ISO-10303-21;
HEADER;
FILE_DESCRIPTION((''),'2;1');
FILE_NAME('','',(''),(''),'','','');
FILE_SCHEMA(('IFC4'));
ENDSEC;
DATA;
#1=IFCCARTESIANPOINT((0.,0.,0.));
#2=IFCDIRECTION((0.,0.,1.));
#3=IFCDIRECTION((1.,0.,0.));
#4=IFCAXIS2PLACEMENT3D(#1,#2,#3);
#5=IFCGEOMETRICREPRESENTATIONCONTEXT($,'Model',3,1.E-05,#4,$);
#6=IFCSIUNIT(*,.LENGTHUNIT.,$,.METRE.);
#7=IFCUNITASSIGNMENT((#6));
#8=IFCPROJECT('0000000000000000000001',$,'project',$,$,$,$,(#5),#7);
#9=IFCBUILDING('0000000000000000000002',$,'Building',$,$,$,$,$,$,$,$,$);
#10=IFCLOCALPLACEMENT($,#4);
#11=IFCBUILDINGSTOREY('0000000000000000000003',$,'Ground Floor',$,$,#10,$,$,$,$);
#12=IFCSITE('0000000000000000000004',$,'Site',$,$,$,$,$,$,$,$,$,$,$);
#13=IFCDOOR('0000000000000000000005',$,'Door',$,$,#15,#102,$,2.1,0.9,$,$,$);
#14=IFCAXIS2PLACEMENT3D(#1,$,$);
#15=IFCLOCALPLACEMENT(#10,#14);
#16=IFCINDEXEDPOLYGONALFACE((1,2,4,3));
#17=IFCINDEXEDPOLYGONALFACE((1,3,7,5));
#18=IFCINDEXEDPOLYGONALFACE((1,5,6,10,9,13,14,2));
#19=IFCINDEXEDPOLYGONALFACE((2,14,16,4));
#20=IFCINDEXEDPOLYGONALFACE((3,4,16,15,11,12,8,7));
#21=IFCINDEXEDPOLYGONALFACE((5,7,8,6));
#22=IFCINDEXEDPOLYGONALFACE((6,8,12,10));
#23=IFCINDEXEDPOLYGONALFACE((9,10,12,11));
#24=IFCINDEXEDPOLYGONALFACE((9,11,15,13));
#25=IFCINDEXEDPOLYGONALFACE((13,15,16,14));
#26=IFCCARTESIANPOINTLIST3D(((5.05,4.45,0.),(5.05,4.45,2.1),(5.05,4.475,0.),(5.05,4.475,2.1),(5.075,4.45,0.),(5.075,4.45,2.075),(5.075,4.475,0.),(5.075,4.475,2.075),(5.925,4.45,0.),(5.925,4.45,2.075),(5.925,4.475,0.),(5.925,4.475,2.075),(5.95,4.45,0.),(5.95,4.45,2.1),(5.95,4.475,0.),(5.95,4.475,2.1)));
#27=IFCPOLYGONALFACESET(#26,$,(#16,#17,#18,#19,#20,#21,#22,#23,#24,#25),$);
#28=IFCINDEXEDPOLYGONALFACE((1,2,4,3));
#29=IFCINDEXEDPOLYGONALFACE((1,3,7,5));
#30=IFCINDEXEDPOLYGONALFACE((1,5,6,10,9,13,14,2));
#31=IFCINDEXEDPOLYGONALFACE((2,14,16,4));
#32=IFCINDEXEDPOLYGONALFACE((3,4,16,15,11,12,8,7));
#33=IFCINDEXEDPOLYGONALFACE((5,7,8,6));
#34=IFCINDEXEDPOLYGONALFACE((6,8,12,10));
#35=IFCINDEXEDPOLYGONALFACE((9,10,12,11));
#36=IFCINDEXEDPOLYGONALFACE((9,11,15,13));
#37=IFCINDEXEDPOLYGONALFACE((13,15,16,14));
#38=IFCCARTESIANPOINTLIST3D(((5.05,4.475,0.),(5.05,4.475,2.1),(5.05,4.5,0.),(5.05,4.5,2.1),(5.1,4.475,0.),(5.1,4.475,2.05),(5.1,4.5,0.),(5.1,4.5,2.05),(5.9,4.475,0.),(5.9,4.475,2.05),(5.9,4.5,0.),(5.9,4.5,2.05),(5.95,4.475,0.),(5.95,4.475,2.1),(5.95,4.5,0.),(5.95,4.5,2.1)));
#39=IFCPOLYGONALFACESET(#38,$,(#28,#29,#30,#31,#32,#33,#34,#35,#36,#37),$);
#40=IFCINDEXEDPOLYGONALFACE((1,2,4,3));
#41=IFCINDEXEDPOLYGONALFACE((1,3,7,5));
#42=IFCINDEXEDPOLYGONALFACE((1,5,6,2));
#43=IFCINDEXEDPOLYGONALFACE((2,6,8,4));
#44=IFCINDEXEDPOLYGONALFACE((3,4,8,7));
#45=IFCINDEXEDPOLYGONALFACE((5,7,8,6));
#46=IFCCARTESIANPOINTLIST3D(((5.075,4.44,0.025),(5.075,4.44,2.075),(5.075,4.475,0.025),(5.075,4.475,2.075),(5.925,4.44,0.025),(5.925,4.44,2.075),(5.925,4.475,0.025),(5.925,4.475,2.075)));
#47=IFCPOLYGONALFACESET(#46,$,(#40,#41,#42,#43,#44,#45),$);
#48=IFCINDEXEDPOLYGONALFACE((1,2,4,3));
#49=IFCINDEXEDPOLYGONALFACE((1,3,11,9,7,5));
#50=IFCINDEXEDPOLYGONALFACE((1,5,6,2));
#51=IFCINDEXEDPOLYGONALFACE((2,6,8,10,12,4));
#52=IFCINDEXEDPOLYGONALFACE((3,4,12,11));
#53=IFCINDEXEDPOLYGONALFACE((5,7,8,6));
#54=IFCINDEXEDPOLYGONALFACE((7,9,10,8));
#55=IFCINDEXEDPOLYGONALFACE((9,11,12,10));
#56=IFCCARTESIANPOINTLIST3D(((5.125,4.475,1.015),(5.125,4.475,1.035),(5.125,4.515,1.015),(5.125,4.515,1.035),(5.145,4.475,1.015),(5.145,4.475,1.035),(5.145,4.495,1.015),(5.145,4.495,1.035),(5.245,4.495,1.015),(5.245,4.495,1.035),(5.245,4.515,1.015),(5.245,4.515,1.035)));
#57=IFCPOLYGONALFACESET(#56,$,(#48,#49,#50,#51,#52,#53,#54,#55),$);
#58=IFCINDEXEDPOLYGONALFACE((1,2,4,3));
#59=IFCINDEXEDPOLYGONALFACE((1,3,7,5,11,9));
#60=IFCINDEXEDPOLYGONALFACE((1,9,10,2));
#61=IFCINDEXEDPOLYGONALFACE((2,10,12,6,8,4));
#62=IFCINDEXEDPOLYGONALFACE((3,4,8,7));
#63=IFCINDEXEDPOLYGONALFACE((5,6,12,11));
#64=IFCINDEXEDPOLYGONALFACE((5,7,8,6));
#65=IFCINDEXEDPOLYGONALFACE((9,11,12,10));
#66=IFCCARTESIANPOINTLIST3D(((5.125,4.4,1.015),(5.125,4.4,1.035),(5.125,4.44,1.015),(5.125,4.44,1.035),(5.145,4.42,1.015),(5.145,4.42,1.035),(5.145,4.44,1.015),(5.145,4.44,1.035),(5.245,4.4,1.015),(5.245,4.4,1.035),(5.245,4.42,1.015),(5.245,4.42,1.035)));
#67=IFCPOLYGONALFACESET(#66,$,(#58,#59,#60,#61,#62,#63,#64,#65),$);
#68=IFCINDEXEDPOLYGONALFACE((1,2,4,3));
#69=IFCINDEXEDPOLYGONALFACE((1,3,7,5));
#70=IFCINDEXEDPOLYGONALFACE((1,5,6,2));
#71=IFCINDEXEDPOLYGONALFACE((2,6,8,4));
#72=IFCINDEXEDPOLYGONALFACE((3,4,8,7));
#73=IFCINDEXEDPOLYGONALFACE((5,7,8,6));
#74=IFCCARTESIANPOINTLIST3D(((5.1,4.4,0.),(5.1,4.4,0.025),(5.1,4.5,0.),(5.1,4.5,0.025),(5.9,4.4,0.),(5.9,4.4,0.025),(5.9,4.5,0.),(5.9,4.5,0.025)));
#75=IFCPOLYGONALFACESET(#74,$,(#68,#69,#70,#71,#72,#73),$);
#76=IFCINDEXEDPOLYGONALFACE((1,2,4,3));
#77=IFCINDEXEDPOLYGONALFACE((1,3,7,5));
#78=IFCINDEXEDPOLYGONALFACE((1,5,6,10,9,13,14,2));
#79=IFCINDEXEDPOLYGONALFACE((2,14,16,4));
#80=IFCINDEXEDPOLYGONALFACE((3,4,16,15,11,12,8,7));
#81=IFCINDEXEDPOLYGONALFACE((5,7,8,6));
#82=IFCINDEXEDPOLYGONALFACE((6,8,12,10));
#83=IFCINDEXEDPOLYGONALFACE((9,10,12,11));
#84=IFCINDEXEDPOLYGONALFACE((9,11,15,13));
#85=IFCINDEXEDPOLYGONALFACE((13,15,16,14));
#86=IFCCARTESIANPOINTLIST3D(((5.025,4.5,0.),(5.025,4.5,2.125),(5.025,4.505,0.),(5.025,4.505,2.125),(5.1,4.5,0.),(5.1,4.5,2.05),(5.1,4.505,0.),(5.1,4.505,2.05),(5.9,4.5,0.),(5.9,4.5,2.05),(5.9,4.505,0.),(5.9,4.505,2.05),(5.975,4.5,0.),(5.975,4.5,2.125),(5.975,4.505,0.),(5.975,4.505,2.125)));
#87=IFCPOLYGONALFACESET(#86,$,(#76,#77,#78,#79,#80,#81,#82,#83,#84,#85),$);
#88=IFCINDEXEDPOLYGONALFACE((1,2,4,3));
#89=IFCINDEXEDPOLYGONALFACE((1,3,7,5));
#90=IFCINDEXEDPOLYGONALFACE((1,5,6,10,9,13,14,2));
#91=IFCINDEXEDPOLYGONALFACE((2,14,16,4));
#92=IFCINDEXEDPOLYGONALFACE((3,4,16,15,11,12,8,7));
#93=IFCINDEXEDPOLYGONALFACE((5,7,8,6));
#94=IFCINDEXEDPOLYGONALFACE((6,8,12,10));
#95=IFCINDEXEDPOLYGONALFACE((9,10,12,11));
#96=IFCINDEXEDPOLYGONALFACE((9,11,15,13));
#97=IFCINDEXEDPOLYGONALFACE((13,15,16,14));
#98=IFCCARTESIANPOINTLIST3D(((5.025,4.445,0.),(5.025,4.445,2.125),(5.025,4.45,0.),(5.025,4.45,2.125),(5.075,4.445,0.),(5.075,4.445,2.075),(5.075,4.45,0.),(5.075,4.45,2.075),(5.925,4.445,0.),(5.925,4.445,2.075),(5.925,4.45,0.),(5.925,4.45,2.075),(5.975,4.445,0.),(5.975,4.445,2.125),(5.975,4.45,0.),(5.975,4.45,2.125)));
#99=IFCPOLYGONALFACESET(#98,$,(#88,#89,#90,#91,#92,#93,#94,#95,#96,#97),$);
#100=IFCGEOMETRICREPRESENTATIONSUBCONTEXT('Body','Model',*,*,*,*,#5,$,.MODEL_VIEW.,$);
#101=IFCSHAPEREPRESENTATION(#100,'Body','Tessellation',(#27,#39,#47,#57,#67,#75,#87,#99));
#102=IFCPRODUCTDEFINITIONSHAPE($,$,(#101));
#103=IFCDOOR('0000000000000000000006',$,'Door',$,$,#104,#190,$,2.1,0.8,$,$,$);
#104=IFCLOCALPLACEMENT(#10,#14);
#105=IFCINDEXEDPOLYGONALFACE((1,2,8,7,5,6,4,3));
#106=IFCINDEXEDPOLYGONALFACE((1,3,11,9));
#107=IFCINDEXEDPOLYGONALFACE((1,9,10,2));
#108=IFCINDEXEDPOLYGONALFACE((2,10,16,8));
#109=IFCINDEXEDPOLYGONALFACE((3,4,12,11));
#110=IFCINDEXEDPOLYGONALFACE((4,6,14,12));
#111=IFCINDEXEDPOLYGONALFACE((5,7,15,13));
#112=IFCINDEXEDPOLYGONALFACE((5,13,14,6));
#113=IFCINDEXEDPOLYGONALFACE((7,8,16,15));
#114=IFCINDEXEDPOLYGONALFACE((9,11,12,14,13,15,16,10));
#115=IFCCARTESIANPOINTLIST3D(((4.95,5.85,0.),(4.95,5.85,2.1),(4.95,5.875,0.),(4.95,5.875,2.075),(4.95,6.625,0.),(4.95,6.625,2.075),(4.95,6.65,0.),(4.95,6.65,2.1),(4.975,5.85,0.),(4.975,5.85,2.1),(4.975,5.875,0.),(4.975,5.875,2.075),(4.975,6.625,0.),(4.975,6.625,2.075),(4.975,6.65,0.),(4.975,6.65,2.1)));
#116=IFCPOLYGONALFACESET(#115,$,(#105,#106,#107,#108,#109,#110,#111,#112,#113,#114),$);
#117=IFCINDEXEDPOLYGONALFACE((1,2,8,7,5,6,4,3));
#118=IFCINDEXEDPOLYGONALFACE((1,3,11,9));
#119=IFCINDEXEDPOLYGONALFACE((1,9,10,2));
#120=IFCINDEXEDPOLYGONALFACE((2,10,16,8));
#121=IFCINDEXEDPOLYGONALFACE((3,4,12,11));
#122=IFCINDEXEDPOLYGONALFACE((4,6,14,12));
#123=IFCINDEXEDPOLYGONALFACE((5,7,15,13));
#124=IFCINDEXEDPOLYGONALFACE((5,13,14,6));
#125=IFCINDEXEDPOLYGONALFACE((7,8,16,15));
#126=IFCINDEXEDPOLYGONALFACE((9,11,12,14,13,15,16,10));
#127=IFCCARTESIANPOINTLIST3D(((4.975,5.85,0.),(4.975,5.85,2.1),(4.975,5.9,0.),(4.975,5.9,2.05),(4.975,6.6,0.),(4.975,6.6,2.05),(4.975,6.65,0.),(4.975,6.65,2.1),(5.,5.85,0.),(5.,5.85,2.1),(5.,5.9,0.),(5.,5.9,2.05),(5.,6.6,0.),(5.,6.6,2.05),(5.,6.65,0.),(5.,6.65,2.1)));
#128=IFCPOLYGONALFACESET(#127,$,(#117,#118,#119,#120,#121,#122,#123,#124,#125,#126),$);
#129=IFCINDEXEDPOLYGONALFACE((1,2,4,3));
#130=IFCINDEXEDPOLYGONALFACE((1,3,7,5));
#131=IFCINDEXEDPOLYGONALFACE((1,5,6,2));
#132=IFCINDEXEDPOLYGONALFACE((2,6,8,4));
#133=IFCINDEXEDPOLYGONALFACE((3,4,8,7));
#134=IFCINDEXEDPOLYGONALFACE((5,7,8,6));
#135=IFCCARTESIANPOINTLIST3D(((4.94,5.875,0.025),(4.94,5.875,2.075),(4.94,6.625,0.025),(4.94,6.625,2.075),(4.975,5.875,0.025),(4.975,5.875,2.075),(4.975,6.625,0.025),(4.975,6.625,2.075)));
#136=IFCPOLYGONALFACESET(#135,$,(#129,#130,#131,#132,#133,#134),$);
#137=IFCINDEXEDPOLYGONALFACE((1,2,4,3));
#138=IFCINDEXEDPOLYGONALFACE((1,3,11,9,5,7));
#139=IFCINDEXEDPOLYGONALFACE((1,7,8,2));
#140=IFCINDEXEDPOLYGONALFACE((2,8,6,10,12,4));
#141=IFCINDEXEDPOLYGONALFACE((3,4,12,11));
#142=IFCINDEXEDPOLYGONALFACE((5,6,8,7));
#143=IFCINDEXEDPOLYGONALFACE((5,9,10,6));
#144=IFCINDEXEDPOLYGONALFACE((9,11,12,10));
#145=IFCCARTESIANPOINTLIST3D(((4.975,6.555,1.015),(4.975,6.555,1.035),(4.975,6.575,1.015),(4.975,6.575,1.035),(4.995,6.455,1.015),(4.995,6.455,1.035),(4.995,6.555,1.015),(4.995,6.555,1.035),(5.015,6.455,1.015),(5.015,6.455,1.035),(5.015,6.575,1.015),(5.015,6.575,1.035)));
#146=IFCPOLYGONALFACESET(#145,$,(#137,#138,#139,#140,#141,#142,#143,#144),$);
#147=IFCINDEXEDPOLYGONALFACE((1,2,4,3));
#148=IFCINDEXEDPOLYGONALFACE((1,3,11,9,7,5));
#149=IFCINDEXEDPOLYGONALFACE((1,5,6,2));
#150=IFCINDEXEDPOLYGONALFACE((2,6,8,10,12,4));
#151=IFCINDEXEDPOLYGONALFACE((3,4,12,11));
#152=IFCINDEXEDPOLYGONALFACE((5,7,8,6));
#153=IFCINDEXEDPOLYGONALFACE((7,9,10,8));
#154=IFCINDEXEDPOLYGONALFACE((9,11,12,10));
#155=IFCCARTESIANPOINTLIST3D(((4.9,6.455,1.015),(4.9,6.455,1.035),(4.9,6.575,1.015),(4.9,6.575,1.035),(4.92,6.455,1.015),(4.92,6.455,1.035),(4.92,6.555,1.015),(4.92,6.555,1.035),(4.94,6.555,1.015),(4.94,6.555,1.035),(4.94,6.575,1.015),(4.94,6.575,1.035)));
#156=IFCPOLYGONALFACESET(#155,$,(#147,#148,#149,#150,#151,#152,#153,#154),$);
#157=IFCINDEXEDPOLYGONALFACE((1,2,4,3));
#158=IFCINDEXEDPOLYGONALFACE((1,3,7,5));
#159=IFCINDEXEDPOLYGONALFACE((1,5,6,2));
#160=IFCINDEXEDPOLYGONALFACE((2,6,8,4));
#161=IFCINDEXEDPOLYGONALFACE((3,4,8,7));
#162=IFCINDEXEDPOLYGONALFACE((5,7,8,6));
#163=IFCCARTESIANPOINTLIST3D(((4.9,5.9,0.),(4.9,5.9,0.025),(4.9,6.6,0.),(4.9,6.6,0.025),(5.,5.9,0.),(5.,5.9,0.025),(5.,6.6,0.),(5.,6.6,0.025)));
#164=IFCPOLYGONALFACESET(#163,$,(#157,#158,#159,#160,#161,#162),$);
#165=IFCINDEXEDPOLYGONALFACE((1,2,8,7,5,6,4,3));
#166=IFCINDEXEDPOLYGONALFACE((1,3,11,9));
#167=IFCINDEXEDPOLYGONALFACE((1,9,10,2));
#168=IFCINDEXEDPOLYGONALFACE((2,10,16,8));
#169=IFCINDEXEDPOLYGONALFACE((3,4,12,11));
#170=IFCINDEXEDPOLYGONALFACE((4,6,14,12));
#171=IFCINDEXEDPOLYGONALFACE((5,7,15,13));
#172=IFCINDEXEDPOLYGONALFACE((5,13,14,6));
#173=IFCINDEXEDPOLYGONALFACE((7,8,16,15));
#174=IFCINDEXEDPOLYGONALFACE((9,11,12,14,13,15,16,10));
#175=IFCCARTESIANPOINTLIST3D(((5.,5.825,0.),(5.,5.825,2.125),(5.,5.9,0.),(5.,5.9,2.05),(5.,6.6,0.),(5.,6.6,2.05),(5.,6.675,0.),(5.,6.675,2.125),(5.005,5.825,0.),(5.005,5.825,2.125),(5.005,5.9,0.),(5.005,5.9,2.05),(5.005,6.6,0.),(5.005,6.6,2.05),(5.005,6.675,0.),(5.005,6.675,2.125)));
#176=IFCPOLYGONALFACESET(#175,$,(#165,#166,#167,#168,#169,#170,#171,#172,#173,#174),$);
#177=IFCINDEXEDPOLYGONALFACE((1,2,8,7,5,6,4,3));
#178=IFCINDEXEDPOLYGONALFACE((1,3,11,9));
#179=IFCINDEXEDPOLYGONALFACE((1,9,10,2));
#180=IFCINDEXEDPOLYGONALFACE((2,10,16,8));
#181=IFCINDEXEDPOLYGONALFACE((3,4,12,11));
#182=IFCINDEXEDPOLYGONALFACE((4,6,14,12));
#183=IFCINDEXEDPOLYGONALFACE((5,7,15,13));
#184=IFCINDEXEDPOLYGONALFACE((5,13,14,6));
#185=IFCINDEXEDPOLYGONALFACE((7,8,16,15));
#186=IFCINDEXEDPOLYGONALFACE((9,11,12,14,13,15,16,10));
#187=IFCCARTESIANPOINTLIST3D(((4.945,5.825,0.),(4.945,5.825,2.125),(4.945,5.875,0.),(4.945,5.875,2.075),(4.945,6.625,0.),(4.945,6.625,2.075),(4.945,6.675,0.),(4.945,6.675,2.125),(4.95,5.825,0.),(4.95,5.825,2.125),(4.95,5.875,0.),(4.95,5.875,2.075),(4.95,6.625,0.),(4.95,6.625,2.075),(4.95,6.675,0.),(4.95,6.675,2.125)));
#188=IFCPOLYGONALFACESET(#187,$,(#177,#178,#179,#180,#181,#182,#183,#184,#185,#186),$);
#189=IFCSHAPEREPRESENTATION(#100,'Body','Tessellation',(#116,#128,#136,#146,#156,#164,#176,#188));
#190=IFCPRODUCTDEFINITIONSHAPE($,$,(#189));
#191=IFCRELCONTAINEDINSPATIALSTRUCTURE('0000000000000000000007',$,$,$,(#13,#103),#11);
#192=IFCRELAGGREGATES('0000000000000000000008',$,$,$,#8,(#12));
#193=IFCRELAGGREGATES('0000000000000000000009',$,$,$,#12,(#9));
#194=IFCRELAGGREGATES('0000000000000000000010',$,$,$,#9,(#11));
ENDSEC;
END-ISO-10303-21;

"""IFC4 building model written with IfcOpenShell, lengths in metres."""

from ifc_helpers import new_model, si_unit, frame, origin_with_axes, place, context, subcontext, project, spatial, line, indexed_curve, outline, extrude, element, save


model = new_model("IFC4")

# Units and contexts
model_context = context("Model", 3, precision=1e-05, world=origin_with_axes())
body_context = subcontext(model_context, "Body", "Model", "MODEL_VIEW")
ifc_project = project(units=[si_unit("LENGTHUNIT", "METRE")], contexts=[model_context])

# Site, building, storey
site = spatial("IfcSite", under=ifc_project, Name="Site")
building = spatial("IfcBuilding", under=site, Name="Building")
storey_placement = place(None, origin_with_axes())
storey = spatial("IfcBuildingStorey", under=building, at=storey_placement, Name="Ground Floor")

# Doors
door_1_placement = place(storey_placement, frame((5.95, 4.5, 0.0), z_axis=(0.0, 0.0, 1.0), x_axis=(-1.0, 0.0, 0.0)))
element("IfcDoor", 1, at=door_1_placement, inside=storey, Name="Door", OverallHeight=2.1, OverallWidth=0.9, context=body_context, shape_type="SweptSolid", body=[
    extrude(outline(indexed_curve([(0.0, 0.0), (0.0, 2.1), (0.9, 2.1), (0.9, 0.0), (0.875, 0.0), (0.875, 2.075), (0.025, 2.075), (0.025, 0.0)], segments=[line(1, 2, 3, 4, 5, 6, 7, 8, 1)])), frame((0.0, 0.025, 0.0), z_axis=(0.0, -1.0, 0.0), x_axis=(1.0, 0.0, 0.0)), (0.0, 0.0, -1.0), 0.025),
    extrude(outline(indexed_curve([(0.0, 0.0), (0.0, 2.1), (0.9, 2.1), (0.9, 0.0), (0.85, 0.0), (0.85, 2.05), (0.05, 2.05), (0.05, 0.0)], segments=[line(1, 2, 3, 4, 5, 6, 7, 8, 1)])), frame((0.0, 0.0, 0.0), z_axis=(0.0, -1.0, 0.0), x_axis=(1.0, 0.0, 0.0)), (0.0, 0.0, -1.0), 0.025),
    extrude(outline(indexed_curve([(0.0, 0.0), (0.85, 0.0), (0.85, 0.035), (0.0, 0.035)], segments=[line(1, 2, 3, 4, 1)])), frame((0.025, 0.025, 0.025), z_axis=(0.0, 0.0, 1.0), x_axis=(1.0, 0.0, 0.0)), (0.0, 0.0, 1.0), 2.05),
    extrude(outline(indexed_curve([(0.0, 0.0), (0.0, -0.04), (-0.12, -0.04), (-0.12, -0.02), (-0.02, -0.02), (-0.02, 0.0)], segments=[line(1, 2, 3, 4, 5, 6, 1)])), frame((0.825, 0.025, 1.015), z_axis=(0.0, 0.0, 1.0), x_axis=(1.0, 0.0, 0.0)), (0.0, 0.0, 1.0), 0.02),
    extrude(outline(indexed_curve([(0.0, 0.0), (0.0, 0.04), (-0.12, 0.04), (-0.12, 0.02), (-0.02, 0.02), (-0.02, 0.0)], segments=[line(1, 2, 3, 4, 5, 6, 1)])), frame((0.825, 0.06, 1.015), z_axis=(0.0, 0.0, 1.0), x_axis=(1.0, 0.0, 0.0)), (0.0, 0.0, 1.0), 0.02),
    extrude(outline(indexed_curve([(0.0, 0.0), (0.8, 0.0), (0.8, 0.1), (0.0, 0.1)], segments=[line(1, 2, 3, 4, 1)])), frame((0.05, 0.0, 0.0), z_axis=(0.0, 0.0, 1.0), x_axis=(1.0, 0.0, 0.0)), (0.0, 0.0, 1.0), 0.025),
    extrude(outline(indexed_curve([(0.0, 0.0), (0.0, 2.125), (0.95, 2.125), (0.95, 0.0), (0.875, 0.0), (0.875, 2.05), (0.075, 2.05), (0.075, 0.0)], segments=[line(1, 2, 3, 4, 5, 6, 7, 8, 1)])), frame((-0.025, -0.005, 0.0), z_axis=(0.0, -1.0, 0.0), x_axis=(1.0, 0.0, 0.0)), (0.0, 0.0, -1.0), 0.005),
    extrude(outline(indexed_curve([(0.0, 0.0), (0.0, 2.125), (0.95, 2.125), (0.95, 0.0), (0.9, 0.0), (0.9, 2.075), (0.05, 2.075), (0.05, 0.0)], segments=[line(1, 2, 3, 4, 5, 6, 7, 8, 1)])), frame((-0.025, 0.05, 0.0), z_axis=(0.0, -1.0, 0.0), x_axis=(1.0, 0.0, 0.0)), (0.0, 0.0, -1.0), 0.005),
])
door_2_placement = place(storey_placement, frame((5.0, 5.85, 0.0), z_axis=(0.0, 0.0, 1.0), x_axis=(0.0, 1.0, 0.0)))
element("IfcDoor", 2, at=door_2_placement, inside=storey, Name="Door", OverallHeight=2.1, OverallWidth=0.8, context=body_context, shape_type="SweptSolid", body=[
    extrude(outline(indexed_curve([(0.0, 0.0), (0.0, 2.1), (0.8, 2.1), (0.8, 0.0), (0.775, 0.0), (0.775, 2.075), (0.025, 2.075), (0.025, 0.0)], segments=[line(1, 2, 3, 4, 5, 6, 7, 8, 1)])), frame((0.0, 0.025, 0.0), z_axis=(0.0, -1.0, 0.0), x_axis=(1.0, 0.0, 0.0)), (0.0, 0.0, -1.0), 0.025),
    extrude(outline(indexed_curve([(0.0, 0.0), (0.0, 2.1), (0.8, 2.1), (0.8, 0.0), (0.75, 0.0), (0.75, 2.05), (0.05, 2.05), (0.05, 0.0)], segments=[line(1, 2, 3, 4, 5, 6, 7, 8, 1)])), frame((0.0, 0.0, 0.0), z_axis=(0.0, -1.0, 0.0), x_axis=(1.0, 0.0, 0.0)), (0.0, 0.0, -1.0), 0.025),
    extrude(outline(indexed_curve([(0.0, 0.0), (0.75, 0.0), (0.75, 0.035), (0.0, 0.035)], segments=[line(1, 2, 3, 4, 1)])), frame((0.025, 0.025, 0.025), z_axis=(0.0, 0.0, 1.0), x_axis=(1.0, 0.0, 0.0)), (0.0, 0.0, 1.0), 2.05),
    extrude(outline(indexed_curve([(0.0, 0.0), (0.0, -0.04), (-0.12, -0.04), (-0.12, -0.02), (-0.02, -0.02), (-0.02, 0.0)], segments=[line(1, 2, 3, 4, 5, 6, 1)])), frame((0.725, 0.025, 1.015), z_axis=(0.0, 0.0, 1.0), x_axis=(1.0, 0.0, 0.0)), (0.0, 0.0, 1.0), 0.02),
    extrude(outline(indexed_curve([(0.0, 0.0), (0.0, 0.04), (-0.12, 0.04), (-0.12, 0.02), (-0.02, 0.02), (-0.02, 0.0)], segments=[line(1, 2, 3, 4, 5, 6, 1)])), frame((0.725, 0.06, 1.015), z_axis=(0.0, 0.0, 1.0), x_axis=(1.0, 0.0, 0.0)), (0.0, 0.0, 1.0), 0.02),
    extrude(outline(indexed_curve([(0.0, 0.0), (0.7, 0.0), (0.7, 0.1), (0.0, 0.1)], segments=[line(1, 2, 3, 4, 1)])), frame((0.05, 0.0, 0.0), z_axis=(0.0, 0.0, 1.0), x_axis=(1.0, 0.0, 0.0)), (0.0, 0.0, 1.0), 0.025),
    extrude(outline(indexed_curve([(0.0, 0.0), (0.0, 2.125), (0.85, 2.125), (0.85, 0.0), (0.775, 0.0), (0.775, 2.05), (0.075, 2.05), (0.075, 0.0)], segments=[line(1, 2, 3, 4, 5, 6, 7, 8, 1)])), frame((-0.025, -0.005, 0.0), z_axis=(0.0, -1.0, 0.0), x_axis=(1.0, 0.0, 0.0)), (0.0, 0.0, -1.0), 0.005),
    extrude(outline(indexed_curve([(0.0, 0.0), (0.0, 2.125), (0.85, 2.125), (0.85, 0.0), (0.8, 0.0), (0.8, 2.075), (0.05, 2.075), (0.05, 0.0)], segments=[line(1, 2, 3, 4, 5, 6, 7, 8, 1)])), frame((-0.025, 0.05, 0.0), z_axis=(0.0, -1.0, 0.0), x_axis=(1.0, 0.0, 0.0)), (0.0, 0.0, -1.0), 0.005),
])

save(model, "model.ifc")
